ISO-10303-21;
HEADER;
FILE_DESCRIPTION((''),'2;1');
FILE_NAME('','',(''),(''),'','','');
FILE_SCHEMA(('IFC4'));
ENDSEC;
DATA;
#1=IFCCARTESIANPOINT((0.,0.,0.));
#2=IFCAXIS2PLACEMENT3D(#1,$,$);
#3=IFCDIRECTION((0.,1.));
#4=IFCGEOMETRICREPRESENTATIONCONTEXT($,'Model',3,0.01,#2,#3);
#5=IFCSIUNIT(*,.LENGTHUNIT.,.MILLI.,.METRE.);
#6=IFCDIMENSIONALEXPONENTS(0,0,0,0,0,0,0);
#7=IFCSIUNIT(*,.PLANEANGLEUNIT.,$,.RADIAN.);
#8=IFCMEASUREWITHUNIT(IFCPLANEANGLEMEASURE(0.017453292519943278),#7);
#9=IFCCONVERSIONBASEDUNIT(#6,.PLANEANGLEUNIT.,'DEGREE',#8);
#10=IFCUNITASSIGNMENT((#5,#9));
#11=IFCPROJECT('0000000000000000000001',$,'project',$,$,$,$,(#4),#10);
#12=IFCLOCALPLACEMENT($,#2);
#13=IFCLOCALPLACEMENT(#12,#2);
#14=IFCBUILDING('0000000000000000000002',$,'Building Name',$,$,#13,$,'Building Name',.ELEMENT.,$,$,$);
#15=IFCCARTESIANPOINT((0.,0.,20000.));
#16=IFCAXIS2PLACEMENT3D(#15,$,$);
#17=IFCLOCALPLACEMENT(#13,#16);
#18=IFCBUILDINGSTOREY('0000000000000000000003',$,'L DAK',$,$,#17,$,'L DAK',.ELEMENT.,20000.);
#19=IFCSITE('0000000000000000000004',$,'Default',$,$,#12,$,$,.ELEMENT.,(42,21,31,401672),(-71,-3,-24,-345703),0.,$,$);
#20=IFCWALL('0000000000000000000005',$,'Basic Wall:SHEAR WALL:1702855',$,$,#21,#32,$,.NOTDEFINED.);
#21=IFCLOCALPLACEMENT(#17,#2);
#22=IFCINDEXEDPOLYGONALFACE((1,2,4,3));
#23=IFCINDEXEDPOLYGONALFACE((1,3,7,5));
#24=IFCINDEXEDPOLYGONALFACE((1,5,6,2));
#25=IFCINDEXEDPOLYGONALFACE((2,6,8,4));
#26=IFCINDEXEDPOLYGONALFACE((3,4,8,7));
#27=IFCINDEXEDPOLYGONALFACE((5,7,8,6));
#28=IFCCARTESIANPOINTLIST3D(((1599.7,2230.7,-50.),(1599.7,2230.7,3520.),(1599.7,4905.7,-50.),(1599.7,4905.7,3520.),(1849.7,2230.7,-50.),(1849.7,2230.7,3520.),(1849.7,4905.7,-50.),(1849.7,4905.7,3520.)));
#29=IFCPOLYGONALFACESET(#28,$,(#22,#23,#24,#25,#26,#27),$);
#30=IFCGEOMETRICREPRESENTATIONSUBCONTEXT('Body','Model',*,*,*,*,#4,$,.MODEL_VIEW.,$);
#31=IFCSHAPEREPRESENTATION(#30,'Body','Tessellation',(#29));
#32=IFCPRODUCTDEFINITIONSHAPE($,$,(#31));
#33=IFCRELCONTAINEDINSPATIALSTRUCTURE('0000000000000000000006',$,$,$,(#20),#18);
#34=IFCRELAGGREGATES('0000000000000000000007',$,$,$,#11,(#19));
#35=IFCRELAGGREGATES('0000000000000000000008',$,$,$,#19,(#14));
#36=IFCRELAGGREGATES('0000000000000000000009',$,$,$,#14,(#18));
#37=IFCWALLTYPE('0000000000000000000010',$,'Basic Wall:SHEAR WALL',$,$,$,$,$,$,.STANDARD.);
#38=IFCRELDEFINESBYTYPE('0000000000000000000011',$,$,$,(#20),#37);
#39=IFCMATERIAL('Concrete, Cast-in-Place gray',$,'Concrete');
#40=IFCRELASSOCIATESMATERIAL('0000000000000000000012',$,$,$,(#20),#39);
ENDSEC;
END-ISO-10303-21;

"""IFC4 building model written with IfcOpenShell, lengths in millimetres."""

from ifc_helpers import new_model, entity, si_unit, converted_unit, direction, frame, origin, place, context, subcontext, project, spatial, indexed_curve, outline, extrude, material, type_object, element, save


model = new_model("IFC4")

# Units and contexts
model_context = context("Model", 3, precision=0.01, world=origin(), true_north=direction((0.0, 1.0)))
body_context = subcontext(model_context, "Body", "Model", "MODEL_VIEW")
ifc_project = project(units=[si_unit("LENGTHUNIT", "METRE", prefix="MILLI"), converted_unit("PLANEANGLEUNIT", "DEGREE", entity("IfcPlaneAngleMeasure", 0.017453292519943278), si_unit("PLANEANGLEUNIT", "RADIAN"), dimensions=[0, 0, 0, 0, 0, 0, 0])], contexts=[model_context])

# Site, building, storey
site_placement = place(None, origin())
site = spatial("IfcSite", under=ifc_project, at=site_placement, Name="Default", CompositionType="ELEMENT", RefLatitude=(42, 21, 31, 401672), RefLongitude=(-71, -3, -24, -345703), RefElevation=0.0)
building_placement = place(site_placement, origin())
building = spatial("IfcBuilding", under=site, at=building_placement, Name="Building Name", LongName="Building Name", CompositionType="ELEMENT")
storey_placement = place(building_placement, frame((0.0, 0.0, 20000.0)))
storey = spatial("IfcBuildingStorey", under=building, at=storey_placement, Name="L DAK", LongName="L DAK", CompositionType="ELEMENT", Elevation=20000.0)

# Shared definitions
ifc_material = material(Name="Concrete, Cast-in-Place gray", Category="Concrete")

# Wall
wall_type = type_object("IfcWallType", Name="Basic Wall:SHEAR WALL", PredefinedType="STANDARD")
wall_1_placement = place(storey_placement, frame((1724.7, 4905.7, -50.0), z_axis=(0.0, 0.0, 1.0), x_axis=(0.0, -1.0, 0.0)))
element("IfcWall", 1, at=wall_1_placement, inside=storey, type_object=wall_type, material=ifc_material, Name="Basic Wall:SHEAR WALL:1702855", PredefinedType="NOTDEFINED", context=body_context, shape_type="SweptSolid", body=[
    extrude(outline(indexed_curve([(2675.0, 125.0), (0.0, 125.0), (0.0, -125.0), (2675.0, -125.0), (2675.0, 125.0)], self_intersect=False)), origin(), (0.0, 0.0, 1.0), 3570.0),
])

save(model, "model.ifc")
